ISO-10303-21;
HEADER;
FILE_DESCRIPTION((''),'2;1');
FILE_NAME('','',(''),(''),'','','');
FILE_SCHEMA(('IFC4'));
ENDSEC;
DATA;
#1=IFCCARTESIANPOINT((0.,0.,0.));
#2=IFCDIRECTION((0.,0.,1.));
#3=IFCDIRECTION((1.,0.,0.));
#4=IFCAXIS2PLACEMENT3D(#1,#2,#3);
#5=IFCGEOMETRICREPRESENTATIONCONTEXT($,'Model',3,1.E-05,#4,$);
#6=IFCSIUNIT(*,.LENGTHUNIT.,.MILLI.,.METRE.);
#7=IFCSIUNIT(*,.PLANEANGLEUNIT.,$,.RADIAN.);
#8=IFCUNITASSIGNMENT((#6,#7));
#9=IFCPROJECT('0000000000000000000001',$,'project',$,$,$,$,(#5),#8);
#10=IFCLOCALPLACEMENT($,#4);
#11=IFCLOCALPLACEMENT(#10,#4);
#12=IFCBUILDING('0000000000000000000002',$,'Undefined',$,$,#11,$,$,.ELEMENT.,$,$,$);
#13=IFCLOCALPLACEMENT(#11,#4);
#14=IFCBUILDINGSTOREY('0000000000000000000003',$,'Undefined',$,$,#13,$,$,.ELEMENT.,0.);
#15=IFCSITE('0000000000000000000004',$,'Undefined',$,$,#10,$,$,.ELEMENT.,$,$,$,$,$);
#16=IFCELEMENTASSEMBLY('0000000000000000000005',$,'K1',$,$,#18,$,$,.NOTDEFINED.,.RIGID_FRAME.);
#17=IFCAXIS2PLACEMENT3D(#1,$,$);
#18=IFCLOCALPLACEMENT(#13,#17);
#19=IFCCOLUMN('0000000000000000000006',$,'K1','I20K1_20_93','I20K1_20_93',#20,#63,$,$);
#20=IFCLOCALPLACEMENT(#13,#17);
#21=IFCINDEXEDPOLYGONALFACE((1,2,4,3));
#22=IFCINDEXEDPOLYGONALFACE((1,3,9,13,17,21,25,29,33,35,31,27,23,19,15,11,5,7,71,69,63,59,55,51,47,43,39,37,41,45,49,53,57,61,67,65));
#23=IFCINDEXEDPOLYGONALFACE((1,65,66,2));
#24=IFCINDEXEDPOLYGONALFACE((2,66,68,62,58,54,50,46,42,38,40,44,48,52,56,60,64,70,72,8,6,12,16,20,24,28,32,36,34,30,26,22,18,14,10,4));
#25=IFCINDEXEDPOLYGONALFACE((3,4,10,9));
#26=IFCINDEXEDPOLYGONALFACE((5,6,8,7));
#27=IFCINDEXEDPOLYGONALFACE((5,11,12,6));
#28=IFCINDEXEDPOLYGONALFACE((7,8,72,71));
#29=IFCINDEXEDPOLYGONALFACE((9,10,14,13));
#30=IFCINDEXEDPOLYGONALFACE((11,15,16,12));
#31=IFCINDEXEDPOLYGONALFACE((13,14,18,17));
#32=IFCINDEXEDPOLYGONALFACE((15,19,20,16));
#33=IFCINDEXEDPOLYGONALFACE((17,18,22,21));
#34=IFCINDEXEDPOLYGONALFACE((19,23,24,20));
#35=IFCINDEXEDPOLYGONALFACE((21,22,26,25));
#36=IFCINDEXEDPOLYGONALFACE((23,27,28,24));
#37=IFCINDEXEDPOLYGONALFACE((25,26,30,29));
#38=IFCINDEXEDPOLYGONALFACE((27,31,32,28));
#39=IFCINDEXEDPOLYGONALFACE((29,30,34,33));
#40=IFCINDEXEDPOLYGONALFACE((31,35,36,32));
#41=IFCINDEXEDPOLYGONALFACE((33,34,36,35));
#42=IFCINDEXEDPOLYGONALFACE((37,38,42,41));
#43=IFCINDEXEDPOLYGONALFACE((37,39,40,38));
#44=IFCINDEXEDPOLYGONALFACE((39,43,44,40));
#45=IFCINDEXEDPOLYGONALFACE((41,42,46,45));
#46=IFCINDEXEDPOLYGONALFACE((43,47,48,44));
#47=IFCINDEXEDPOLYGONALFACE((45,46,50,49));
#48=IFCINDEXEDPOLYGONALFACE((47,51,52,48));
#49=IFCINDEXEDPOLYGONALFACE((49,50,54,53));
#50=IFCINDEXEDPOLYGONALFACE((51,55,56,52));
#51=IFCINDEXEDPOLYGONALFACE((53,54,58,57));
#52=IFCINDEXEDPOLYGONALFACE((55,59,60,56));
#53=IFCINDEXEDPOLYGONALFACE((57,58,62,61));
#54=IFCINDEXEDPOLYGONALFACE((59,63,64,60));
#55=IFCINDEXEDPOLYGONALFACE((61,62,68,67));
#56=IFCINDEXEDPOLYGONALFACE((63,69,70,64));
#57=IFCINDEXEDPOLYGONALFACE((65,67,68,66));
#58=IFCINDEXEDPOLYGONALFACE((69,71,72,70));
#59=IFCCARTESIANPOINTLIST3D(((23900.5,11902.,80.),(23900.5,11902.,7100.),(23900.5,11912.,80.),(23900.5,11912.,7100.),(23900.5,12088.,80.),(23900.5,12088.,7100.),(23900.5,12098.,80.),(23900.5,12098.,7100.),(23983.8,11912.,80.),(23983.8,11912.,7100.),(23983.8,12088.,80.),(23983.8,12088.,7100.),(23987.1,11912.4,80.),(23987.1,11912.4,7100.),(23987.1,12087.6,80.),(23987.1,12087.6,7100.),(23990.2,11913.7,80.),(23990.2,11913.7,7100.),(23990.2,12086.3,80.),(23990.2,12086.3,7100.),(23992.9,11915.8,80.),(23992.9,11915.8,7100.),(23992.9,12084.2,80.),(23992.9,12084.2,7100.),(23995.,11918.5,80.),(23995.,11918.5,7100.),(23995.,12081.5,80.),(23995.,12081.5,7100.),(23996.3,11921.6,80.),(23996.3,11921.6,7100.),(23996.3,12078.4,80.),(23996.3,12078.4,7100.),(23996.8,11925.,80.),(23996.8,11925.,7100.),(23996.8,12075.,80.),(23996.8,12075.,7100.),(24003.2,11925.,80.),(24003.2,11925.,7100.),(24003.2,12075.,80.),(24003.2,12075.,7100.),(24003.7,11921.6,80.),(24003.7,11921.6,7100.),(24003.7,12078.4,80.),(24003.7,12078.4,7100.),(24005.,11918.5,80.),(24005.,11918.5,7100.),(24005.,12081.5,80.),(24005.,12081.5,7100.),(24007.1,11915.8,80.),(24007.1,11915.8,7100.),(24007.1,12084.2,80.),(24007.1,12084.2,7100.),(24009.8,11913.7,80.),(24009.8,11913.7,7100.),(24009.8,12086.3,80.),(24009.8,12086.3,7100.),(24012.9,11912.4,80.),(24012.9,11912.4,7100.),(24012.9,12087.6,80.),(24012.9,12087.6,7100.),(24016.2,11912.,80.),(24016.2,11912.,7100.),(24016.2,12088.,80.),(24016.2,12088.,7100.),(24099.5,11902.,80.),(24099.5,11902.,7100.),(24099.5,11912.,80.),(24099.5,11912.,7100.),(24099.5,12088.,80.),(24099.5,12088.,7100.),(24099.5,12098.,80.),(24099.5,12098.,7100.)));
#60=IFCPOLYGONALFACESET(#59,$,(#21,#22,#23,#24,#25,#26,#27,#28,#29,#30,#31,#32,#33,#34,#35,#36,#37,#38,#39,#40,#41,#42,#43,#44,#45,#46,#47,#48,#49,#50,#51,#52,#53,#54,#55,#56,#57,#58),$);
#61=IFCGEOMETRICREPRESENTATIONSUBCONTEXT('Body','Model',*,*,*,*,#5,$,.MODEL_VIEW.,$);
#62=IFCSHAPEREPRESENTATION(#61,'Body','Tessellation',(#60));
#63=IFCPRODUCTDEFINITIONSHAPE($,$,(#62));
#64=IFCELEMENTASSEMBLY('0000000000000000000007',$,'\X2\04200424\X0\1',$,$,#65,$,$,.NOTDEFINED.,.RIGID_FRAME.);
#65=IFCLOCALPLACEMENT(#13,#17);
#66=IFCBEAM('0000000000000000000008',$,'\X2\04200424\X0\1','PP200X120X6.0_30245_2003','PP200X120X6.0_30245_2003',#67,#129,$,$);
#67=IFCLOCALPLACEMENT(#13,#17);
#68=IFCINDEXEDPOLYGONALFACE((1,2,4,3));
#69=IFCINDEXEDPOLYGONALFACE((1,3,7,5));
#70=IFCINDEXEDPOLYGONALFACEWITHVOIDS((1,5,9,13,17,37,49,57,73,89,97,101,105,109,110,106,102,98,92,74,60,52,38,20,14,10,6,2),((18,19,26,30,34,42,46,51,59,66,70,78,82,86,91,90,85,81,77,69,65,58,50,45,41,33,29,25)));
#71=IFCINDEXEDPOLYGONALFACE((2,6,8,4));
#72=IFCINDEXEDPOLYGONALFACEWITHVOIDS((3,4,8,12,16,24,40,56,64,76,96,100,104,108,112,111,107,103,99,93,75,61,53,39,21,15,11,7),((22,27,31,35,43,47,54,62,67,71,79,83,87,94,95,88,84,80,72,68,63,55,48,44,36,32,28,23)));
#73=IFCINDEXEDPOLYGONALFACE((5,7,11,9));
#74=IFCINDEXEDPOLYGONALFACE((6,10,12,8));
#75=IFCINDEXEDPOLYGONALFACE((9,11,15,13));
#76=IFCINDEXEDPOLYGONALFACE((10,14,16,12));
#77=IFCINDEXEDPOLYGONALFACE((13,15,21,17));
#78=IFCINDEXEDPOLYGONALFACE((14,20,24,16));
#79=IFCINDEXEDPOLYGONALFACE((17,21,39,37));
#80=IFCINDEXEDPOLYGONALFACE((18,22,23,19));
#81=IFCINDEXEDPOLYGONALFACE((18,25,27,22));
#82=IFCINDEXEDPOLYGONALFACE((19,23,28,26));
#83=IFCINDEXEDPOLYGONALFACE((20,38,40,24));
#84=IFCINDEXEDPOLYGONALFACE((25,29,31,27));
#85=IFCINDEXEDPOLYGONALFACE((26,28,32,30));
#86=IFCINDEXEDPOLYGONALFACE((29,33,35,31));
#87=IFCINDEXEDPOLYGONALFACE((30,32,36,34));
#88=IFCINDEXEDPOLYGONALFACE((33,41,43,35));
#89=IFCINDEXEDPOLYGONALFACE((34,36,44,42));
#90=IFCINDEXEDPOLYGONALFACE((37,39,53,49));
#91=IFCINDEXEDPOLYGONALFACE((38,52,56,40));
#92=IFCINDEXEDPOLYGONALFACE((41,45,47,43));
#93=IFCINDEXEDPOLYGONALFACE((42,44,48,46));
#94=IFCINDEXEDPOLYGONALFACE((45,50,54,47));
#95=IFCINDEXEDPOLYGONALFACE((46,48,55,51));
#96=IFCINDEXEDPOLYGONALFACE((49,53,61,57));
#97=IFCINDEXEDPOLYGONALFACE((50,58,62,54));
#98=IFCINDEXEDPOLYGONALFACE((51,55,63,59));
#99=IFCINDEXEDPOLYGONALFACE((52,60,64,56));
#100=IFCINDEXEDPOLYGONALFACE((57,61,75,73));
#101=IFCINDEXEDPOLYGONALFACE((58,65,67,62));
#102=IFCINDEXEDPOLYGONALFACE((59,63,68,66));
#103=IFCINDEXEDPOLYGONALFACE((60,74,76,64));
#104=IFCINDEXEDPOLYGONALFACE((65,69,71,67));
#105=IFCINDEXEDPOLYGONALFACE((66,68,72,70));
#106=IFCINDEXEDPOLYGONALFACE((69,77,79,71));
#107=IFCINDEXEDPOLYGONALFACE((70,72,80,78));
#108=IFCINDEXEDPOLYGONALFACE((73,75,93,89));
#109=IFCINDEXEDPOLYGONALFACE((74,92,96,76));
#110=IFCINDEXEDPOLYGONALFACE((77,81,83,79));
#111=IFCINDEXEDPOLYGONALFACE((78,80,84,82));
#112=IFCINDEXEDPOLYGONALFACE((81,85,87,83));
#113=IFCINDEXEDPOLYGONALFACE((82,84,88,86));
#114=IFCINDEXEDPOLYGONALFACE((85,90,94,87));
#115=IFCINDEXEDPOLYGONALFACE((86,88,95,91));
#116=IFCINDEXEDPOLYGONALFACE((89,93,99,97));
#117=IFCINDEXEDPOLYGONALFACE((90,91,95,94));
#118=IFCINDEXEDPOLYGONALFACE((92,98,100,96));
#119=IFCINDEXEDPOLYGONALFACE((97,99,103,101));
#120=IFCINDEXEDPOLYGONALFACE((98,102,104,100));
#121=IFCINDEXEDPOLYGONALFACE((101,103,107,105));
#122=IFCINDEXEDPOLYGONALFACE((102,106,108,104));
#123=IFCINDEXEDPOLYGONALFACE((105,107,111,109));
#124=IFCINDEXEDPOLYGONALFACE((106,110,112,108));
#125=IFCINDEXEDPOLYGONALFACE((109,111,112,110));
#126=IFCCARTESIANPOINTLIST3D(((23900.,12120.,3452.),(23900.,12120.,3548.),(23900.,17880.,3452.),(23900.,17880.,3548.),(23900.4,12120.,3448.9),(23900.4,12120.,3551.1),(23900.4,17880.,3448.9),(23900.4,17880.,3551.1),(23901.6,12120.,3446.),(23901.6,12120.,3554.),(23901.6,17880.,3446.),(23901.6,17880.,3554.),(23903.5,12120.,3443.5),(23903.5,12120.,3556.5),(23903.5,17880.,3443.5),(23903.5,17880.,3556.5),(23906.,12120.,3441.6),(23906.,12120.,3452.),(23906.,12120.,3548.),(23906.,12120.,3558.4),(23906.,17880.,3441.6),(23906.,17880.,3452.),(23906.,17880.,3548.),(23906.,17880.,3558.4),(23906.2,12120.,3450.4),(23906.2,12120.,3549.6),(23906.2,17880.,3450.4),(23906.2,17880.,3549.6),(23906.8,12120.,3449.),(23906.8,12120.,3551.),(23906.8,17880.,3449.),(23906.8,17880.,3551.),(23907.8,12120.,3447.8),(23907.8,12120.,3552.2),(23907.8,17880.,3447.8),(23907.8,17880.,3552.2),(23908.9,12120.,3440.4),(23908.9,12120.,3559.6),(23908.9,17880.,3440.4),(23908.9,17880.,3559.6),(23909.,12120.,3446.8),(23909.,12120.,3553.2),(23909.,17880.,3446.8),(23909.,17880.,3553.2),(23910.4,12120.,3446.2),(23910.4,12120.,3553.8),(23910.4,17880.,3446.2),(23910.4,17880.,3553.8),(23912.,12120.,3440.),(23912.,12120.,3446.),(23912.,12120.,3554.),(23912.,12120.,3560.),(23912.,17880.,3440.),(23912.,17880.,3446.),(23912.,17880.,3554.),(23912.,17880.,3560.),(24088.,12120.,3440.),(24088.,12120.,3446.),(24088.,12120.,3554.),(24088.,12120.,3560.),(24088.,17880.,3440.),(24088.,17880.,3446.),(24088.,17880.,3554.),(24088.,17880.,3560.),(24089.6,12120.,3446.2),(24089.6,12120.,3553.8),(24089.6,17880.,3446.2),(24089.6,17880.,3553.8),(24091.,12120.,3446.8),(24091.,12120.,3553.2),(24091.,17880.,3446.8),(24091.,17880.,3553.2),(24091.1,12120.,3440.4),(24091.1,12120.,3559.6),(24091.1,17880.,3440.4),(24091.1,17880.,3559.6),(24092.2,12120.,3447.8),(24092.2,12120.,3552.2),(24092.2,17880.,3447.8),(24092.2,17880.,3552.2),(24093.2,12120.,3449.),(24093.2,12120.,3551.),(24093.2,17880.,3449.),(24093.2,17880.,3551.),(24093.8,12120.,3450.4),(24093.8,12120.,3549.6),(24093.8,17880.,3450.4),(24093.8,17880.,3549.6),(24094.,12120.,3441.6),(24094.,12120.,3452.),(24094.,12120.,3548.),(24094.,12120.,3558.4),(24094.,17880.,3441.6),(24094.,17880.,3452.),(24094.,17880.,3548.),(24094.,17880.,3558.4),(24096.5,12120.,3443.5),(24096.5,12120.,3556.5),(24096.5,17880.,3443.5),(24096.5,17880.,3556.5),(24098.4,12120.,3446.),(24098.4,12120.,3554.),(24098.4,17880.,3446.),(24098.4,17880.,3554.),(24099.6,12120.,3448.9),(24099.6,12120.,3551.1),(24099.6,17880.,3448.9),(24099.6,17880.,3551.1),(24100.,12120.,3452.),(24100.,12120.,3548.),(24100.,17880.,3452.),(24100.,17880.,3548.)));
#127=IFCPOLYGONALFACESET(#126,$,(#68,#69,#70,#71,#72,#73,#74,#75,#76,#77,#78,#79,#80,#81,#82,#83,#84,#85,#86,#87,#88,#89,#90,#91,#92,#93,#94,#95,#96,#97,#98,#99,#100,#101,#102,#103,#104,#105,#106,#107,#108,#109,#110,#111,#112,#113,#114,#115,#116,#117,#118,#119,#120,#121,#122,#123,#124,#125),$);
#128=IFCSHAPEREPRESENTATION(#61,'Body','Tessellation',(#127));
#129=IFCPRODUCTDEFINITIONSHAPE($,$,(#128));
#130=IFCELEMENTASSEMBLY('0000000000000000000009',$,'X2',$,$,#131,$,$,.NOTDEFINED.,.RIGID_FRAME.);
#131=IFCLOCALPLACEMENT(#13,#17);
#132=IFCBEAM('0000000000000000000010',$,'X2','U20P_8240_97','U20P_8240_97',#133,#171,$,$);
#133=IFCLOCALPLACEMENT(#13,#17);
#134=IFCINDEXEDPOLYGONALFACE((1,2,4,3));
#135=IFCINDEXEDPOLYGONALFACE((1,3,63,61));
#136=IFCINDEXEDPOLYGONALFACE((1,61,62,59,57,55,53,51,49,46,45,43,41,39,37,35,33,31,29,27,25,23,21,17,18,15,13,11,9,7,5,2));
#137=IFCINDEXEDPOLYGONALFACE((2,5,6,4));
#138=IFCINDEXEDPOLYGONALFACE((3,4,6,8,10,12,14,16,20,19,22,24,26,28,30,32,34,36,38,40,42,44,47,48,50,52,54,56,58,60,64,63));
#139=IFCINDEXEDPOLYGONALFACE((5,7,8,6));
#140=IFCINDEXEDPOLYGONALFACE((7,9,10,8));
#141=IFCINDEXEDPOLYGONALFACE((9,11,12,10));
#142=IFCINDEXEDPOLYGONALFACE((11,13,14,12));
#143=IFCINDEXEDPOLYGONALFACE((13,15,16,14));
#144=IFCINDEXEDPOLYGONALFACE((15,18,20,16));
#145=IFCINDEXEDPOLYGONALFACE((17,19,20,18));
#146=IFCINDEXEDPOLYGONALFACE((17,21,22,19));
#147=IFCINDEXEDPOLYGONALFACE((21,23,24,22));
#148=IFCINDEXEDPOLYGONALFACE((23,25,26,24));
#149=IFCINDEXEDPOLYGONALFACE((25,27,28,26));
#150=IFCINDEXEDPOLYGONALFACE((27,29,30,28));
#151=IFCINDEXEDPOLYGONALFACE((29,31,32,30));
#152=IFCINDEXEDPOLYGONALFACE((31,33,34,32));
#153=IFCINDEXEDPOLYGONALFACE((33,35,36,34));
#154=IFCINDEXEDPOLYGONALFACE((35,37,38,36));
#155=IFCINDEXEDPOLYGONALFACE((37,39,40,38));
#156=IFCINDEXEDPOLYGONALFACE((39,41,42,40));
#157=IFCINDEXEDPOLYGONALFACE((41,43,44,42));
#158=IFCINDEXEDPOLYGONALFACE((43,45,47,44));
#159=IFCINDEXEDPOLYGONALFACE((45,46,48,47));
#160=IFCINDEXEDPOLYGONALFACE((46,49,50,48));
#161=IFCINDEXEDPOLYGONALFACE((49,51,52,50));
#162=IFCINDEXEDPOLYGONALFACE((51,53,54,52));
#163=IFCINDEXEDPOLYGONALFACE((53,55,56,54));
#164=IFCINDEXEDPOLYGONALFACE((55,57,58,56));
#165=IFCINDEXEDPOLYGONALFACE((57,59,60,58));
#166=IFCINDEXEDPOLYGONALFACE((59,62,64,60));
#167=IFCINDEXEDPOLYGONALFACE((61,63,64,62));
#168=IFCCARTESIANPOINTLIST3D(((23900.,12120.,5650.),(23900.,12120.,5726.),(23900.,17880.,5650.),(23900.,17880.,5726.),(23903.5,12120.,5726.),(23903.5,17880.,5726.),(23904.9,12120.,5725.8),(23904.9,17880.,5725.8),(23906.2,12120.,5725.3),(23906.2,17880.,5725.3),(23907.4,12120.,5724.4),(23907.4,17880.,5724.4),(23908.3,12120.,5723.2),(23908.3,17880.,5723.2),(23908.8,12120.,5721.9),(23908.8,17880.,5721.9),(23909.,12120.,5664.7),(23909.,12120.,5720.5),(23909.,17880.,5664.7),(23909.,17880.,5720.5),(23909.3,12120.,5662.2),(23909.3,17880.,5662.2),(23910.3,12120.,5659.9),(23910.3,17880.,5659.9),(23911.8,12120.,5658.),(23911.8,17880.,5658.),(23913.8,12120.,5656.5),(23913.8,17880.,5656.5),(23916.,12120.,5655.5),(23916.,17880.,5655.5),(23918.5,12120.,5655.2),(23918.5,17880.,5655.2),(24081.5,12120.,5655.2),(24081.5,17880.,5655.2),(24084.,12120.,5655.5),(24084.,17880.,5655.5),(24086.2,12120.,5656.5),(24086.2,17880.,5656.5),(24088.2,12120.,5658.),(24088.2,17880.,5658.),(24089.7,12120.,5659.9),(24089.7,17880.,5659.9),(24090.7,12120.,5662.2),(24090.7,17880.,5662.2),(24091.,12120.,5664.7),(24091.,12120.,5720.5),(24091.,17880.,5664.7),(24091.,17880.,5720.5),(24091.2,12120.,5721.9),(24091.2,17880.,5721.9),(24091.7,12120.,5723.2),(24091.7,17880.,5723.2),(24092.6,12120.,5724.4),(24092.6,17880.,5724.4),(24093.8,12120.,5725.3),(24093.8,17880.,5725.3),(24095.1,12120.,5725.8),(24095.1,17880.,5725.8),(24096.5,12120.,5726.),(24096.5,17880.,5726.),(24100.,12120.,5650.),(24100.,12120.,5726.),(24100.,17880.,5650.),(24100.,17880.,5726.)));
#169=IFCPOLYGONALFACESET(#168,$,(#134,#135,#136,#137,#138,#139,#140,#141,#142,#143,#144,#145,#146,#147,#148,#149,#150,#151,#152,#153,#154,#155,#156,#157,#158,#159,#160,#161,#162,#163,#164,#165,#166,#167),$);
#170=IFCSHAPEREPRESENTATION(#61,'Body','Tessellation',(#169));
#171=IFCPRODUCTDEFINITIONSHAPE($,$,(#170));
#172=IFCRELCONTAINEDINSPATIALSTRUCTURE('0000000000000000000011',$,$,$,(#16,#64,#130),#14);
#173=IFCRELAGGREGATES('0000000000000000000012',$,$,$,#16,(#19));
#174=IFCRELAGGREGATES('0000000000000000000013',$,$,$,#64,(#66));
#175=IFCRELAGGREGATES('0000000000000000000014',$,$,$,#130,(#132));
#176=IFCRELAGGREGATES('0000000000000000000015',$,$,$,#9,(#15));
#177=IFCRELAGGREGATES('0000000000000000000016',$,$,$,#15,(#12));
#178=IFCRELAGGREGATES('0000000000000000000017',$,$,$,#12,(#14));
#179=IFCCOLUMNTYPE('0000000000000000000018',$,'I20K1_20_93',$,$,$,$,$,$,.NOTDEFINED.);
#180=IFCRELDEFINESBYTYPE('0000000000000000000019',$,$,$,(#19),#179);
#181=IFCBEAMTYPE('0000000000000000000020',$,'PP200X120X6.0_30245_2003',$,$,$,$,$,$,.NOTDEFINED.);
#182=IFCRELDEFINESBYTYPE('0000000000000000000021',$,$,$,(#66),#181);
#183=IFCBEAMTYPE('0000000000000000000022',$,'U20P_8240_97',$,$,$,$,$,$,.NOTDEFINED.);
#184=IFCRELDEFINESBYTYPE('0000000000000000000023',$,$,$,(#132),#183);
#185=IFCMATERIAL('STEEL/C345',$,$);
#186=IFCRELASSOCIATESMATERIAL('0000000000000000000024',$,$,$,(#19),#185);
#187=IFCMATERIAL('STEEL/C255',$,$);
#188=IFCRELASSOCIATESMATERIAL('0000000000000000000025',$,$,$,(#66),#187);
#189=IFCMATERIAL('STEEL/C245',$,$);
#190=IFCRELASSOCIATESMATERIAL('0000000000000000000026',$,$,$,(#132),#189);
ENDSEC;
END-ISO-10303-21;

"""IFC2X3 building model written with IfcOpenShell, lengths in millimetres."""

from ifc_helpers import new_model, si_unit, frame, origin_with_axes, origin_2d_with_axis, place, context, subcontext, project, spatial, hollow_rectangle, i_section, u_section, extrude, material, type_object, element, aggregate, save


model = new_model("IFC2X3")

# Units and contexts
model_context = context("Model", 3, precision=1e-05, world=origin_with_axes())
body_context = subcontext(model_context, "Body", "Model", "MODEL_VIEW")
ifc_project = project(units=[si_unit("LENGTHUNIT", "METRE", prefix="MILLI"), si_unit("PLANEANGLEUNIT", "RADIAN")], contexts=[model_context])

# Site, building, storey
site_placement = place(None, origin_with_axes())
site = spatial("IfcSite", under=ifc_project, at=site_placement, Name="Undefined", CompositionType="ELEMENT")
building_placement = place(site_placement, origin_with_axes())
building = spatial("IfcBuilding", under=site, at=building_placement, Name="Undefined", CompositionType="ELEMENT")
storey_placement = place(building_placement, origin_with_axes())
storey = spatial("IfcBuildingStorey", under=building, at=storey_placement, Name="Undefined", CompositionType="ELEMENT", Elevation=0.0)

# Element assembly, column
ifc_material_1 = material(Name="STEEL/C245")
assembly_1_placement = place(storey_placement, origin_with_axes())
assembly_1 = element("IfcElementAssembly", 1, at=assembly_1_placement, inside=storey, Name="K1", AssemblyPlace="NOTDEFINED", PredefinedType="RIGID_FRAME")
ifc_material_2 = material(Name="STEEL/C345")
column_type_1 = type_object("IfcColumnType", Name="I20K1_20_93", PredefinedType="NOTDEFINED")
column_1_placement = place(assembly_1_placement, frame((24000.0, 12000.0, 80.0), z_axis=(0.0, 0.0, 1.0), x_axis=(0.0, 1.0, 0.0)))
column_1 = element("IfcColumn", 2, at=column_1_placement, type_object=column_type_1, material=ifc_material_2, Name="K1", Description="I20K1_20_93", ObjectType="I20K1_20_93", context=body_context, shape_type="SweptSolid", body=[
    extrude(i_section(OverallWidth=199.0, OverallDepth=196.0, WebThickness=6.5, FlangeThickness=10.0, FilletRadius=13.0, at=origin_2d_with_axis()), frame((0.0, 0.0, 7020.0), z_axis=(0.0, 0.0, -1.0), x_axis=(0.0, 1.0, 0.0)), (0.0, 0.0, 1.0), 7020.0),
])
aggregate(assembly_1, [column_1])

# Element assemblies, beams
assembly_2_placement = place(storey_placement, origin_with_axes())
assembly_2 = element("IfcElementAssembly", 3, at=assembly_2_placement, inside=storey, Name="РФ1", AssemblyPlace="NOTDEFINED", PredefinedType="RIGID_FRAME")
ifc_material_3 = material(Name="STEEL/C255")
beam_type_1 = type_object("IfcBeamType", Name="PP200X120X6.0_30245_2003", PredefinedType="NOTDEFINED")
beam_1_placement = place(assembly_2_placement, frame((24000.0, 12120.0, 3500.0), z_axis=(-1.0, 0.0, 0.0), x_axis=(0.0, 1.0, 0.0)))
beam_1 = element("IfcBeam", 4, at=beam_1_placement, type_object=beam_type_1, material=ifc_material_3, Name="РФ1", Description="PP200X120X6.0_30245_2003", ObjectType="PP200X120X6.0_30245_2003", context=body_context, shape_type="SweptSolid", body=[
    extrude(hollow_rectangle(XDim=120.0, YDim=200.0, WallThickness=6.0, InnerFilletRadius=6.0, OuterFilletRadius=12.0, at=origin_2d_with_axis()), frame((5760.0, 0.0, 0.0), z_axis=(-1.0, 0.0, 0.0), x_axis=(0.0, -1.0, 0.0)), (0.0, 0.0, 1.0), 5760.0),
])
aggregate(assembly_2, [beam_1])
assembly_3_placement = place(storey_placement, origin_with_axes())
assembly_3 = element("IfcElementAssembly", 5, at=assembly_3_placement, inside=storey, Name="X2", AssemblyPlace="NOTDEFINED", PredefinedType="RIGID_FRAME")
beam_type_2 = type_object("IfcBeamType", Name="U20P_8240_97", PredefinedType="NOTDEFINED")
beam_2_placement = place(assembly_3_placement, frame((24000.0, 12120.0, 5688.0), z_axis=(-1.0, 0.0, 0.0), x_axis=(0.0, 1.0, 0.0)))
beam_2 = element("IfcBeam", 6, at=beam_2_placement, type_object=beam_type_2, material=ifc_material_1, Name="X2", Description="U20P_8240_97", ObjectType="U20P_8240_97", context=body_context, shape_type="SweptSolid", body=[
    extrude(u_section(Depth=200.0, FlangeWidth=76.0, WebThickness=5.2, FlangeThickness=9.0, FilletRadius=9.5, EdgeRadius=5.5, at=origin_2d_with_axis()), frame((5760.0, 0.0, 0.0), z_axis=(-1.0, 0.0, 0.0), x_axis=(0.0, -1.0, 0.0)), (0.0, 0.0, 1.0), 5760.0),
])
aggregate(assembly_3, [beam_2])

save(model, "model.ifc")
